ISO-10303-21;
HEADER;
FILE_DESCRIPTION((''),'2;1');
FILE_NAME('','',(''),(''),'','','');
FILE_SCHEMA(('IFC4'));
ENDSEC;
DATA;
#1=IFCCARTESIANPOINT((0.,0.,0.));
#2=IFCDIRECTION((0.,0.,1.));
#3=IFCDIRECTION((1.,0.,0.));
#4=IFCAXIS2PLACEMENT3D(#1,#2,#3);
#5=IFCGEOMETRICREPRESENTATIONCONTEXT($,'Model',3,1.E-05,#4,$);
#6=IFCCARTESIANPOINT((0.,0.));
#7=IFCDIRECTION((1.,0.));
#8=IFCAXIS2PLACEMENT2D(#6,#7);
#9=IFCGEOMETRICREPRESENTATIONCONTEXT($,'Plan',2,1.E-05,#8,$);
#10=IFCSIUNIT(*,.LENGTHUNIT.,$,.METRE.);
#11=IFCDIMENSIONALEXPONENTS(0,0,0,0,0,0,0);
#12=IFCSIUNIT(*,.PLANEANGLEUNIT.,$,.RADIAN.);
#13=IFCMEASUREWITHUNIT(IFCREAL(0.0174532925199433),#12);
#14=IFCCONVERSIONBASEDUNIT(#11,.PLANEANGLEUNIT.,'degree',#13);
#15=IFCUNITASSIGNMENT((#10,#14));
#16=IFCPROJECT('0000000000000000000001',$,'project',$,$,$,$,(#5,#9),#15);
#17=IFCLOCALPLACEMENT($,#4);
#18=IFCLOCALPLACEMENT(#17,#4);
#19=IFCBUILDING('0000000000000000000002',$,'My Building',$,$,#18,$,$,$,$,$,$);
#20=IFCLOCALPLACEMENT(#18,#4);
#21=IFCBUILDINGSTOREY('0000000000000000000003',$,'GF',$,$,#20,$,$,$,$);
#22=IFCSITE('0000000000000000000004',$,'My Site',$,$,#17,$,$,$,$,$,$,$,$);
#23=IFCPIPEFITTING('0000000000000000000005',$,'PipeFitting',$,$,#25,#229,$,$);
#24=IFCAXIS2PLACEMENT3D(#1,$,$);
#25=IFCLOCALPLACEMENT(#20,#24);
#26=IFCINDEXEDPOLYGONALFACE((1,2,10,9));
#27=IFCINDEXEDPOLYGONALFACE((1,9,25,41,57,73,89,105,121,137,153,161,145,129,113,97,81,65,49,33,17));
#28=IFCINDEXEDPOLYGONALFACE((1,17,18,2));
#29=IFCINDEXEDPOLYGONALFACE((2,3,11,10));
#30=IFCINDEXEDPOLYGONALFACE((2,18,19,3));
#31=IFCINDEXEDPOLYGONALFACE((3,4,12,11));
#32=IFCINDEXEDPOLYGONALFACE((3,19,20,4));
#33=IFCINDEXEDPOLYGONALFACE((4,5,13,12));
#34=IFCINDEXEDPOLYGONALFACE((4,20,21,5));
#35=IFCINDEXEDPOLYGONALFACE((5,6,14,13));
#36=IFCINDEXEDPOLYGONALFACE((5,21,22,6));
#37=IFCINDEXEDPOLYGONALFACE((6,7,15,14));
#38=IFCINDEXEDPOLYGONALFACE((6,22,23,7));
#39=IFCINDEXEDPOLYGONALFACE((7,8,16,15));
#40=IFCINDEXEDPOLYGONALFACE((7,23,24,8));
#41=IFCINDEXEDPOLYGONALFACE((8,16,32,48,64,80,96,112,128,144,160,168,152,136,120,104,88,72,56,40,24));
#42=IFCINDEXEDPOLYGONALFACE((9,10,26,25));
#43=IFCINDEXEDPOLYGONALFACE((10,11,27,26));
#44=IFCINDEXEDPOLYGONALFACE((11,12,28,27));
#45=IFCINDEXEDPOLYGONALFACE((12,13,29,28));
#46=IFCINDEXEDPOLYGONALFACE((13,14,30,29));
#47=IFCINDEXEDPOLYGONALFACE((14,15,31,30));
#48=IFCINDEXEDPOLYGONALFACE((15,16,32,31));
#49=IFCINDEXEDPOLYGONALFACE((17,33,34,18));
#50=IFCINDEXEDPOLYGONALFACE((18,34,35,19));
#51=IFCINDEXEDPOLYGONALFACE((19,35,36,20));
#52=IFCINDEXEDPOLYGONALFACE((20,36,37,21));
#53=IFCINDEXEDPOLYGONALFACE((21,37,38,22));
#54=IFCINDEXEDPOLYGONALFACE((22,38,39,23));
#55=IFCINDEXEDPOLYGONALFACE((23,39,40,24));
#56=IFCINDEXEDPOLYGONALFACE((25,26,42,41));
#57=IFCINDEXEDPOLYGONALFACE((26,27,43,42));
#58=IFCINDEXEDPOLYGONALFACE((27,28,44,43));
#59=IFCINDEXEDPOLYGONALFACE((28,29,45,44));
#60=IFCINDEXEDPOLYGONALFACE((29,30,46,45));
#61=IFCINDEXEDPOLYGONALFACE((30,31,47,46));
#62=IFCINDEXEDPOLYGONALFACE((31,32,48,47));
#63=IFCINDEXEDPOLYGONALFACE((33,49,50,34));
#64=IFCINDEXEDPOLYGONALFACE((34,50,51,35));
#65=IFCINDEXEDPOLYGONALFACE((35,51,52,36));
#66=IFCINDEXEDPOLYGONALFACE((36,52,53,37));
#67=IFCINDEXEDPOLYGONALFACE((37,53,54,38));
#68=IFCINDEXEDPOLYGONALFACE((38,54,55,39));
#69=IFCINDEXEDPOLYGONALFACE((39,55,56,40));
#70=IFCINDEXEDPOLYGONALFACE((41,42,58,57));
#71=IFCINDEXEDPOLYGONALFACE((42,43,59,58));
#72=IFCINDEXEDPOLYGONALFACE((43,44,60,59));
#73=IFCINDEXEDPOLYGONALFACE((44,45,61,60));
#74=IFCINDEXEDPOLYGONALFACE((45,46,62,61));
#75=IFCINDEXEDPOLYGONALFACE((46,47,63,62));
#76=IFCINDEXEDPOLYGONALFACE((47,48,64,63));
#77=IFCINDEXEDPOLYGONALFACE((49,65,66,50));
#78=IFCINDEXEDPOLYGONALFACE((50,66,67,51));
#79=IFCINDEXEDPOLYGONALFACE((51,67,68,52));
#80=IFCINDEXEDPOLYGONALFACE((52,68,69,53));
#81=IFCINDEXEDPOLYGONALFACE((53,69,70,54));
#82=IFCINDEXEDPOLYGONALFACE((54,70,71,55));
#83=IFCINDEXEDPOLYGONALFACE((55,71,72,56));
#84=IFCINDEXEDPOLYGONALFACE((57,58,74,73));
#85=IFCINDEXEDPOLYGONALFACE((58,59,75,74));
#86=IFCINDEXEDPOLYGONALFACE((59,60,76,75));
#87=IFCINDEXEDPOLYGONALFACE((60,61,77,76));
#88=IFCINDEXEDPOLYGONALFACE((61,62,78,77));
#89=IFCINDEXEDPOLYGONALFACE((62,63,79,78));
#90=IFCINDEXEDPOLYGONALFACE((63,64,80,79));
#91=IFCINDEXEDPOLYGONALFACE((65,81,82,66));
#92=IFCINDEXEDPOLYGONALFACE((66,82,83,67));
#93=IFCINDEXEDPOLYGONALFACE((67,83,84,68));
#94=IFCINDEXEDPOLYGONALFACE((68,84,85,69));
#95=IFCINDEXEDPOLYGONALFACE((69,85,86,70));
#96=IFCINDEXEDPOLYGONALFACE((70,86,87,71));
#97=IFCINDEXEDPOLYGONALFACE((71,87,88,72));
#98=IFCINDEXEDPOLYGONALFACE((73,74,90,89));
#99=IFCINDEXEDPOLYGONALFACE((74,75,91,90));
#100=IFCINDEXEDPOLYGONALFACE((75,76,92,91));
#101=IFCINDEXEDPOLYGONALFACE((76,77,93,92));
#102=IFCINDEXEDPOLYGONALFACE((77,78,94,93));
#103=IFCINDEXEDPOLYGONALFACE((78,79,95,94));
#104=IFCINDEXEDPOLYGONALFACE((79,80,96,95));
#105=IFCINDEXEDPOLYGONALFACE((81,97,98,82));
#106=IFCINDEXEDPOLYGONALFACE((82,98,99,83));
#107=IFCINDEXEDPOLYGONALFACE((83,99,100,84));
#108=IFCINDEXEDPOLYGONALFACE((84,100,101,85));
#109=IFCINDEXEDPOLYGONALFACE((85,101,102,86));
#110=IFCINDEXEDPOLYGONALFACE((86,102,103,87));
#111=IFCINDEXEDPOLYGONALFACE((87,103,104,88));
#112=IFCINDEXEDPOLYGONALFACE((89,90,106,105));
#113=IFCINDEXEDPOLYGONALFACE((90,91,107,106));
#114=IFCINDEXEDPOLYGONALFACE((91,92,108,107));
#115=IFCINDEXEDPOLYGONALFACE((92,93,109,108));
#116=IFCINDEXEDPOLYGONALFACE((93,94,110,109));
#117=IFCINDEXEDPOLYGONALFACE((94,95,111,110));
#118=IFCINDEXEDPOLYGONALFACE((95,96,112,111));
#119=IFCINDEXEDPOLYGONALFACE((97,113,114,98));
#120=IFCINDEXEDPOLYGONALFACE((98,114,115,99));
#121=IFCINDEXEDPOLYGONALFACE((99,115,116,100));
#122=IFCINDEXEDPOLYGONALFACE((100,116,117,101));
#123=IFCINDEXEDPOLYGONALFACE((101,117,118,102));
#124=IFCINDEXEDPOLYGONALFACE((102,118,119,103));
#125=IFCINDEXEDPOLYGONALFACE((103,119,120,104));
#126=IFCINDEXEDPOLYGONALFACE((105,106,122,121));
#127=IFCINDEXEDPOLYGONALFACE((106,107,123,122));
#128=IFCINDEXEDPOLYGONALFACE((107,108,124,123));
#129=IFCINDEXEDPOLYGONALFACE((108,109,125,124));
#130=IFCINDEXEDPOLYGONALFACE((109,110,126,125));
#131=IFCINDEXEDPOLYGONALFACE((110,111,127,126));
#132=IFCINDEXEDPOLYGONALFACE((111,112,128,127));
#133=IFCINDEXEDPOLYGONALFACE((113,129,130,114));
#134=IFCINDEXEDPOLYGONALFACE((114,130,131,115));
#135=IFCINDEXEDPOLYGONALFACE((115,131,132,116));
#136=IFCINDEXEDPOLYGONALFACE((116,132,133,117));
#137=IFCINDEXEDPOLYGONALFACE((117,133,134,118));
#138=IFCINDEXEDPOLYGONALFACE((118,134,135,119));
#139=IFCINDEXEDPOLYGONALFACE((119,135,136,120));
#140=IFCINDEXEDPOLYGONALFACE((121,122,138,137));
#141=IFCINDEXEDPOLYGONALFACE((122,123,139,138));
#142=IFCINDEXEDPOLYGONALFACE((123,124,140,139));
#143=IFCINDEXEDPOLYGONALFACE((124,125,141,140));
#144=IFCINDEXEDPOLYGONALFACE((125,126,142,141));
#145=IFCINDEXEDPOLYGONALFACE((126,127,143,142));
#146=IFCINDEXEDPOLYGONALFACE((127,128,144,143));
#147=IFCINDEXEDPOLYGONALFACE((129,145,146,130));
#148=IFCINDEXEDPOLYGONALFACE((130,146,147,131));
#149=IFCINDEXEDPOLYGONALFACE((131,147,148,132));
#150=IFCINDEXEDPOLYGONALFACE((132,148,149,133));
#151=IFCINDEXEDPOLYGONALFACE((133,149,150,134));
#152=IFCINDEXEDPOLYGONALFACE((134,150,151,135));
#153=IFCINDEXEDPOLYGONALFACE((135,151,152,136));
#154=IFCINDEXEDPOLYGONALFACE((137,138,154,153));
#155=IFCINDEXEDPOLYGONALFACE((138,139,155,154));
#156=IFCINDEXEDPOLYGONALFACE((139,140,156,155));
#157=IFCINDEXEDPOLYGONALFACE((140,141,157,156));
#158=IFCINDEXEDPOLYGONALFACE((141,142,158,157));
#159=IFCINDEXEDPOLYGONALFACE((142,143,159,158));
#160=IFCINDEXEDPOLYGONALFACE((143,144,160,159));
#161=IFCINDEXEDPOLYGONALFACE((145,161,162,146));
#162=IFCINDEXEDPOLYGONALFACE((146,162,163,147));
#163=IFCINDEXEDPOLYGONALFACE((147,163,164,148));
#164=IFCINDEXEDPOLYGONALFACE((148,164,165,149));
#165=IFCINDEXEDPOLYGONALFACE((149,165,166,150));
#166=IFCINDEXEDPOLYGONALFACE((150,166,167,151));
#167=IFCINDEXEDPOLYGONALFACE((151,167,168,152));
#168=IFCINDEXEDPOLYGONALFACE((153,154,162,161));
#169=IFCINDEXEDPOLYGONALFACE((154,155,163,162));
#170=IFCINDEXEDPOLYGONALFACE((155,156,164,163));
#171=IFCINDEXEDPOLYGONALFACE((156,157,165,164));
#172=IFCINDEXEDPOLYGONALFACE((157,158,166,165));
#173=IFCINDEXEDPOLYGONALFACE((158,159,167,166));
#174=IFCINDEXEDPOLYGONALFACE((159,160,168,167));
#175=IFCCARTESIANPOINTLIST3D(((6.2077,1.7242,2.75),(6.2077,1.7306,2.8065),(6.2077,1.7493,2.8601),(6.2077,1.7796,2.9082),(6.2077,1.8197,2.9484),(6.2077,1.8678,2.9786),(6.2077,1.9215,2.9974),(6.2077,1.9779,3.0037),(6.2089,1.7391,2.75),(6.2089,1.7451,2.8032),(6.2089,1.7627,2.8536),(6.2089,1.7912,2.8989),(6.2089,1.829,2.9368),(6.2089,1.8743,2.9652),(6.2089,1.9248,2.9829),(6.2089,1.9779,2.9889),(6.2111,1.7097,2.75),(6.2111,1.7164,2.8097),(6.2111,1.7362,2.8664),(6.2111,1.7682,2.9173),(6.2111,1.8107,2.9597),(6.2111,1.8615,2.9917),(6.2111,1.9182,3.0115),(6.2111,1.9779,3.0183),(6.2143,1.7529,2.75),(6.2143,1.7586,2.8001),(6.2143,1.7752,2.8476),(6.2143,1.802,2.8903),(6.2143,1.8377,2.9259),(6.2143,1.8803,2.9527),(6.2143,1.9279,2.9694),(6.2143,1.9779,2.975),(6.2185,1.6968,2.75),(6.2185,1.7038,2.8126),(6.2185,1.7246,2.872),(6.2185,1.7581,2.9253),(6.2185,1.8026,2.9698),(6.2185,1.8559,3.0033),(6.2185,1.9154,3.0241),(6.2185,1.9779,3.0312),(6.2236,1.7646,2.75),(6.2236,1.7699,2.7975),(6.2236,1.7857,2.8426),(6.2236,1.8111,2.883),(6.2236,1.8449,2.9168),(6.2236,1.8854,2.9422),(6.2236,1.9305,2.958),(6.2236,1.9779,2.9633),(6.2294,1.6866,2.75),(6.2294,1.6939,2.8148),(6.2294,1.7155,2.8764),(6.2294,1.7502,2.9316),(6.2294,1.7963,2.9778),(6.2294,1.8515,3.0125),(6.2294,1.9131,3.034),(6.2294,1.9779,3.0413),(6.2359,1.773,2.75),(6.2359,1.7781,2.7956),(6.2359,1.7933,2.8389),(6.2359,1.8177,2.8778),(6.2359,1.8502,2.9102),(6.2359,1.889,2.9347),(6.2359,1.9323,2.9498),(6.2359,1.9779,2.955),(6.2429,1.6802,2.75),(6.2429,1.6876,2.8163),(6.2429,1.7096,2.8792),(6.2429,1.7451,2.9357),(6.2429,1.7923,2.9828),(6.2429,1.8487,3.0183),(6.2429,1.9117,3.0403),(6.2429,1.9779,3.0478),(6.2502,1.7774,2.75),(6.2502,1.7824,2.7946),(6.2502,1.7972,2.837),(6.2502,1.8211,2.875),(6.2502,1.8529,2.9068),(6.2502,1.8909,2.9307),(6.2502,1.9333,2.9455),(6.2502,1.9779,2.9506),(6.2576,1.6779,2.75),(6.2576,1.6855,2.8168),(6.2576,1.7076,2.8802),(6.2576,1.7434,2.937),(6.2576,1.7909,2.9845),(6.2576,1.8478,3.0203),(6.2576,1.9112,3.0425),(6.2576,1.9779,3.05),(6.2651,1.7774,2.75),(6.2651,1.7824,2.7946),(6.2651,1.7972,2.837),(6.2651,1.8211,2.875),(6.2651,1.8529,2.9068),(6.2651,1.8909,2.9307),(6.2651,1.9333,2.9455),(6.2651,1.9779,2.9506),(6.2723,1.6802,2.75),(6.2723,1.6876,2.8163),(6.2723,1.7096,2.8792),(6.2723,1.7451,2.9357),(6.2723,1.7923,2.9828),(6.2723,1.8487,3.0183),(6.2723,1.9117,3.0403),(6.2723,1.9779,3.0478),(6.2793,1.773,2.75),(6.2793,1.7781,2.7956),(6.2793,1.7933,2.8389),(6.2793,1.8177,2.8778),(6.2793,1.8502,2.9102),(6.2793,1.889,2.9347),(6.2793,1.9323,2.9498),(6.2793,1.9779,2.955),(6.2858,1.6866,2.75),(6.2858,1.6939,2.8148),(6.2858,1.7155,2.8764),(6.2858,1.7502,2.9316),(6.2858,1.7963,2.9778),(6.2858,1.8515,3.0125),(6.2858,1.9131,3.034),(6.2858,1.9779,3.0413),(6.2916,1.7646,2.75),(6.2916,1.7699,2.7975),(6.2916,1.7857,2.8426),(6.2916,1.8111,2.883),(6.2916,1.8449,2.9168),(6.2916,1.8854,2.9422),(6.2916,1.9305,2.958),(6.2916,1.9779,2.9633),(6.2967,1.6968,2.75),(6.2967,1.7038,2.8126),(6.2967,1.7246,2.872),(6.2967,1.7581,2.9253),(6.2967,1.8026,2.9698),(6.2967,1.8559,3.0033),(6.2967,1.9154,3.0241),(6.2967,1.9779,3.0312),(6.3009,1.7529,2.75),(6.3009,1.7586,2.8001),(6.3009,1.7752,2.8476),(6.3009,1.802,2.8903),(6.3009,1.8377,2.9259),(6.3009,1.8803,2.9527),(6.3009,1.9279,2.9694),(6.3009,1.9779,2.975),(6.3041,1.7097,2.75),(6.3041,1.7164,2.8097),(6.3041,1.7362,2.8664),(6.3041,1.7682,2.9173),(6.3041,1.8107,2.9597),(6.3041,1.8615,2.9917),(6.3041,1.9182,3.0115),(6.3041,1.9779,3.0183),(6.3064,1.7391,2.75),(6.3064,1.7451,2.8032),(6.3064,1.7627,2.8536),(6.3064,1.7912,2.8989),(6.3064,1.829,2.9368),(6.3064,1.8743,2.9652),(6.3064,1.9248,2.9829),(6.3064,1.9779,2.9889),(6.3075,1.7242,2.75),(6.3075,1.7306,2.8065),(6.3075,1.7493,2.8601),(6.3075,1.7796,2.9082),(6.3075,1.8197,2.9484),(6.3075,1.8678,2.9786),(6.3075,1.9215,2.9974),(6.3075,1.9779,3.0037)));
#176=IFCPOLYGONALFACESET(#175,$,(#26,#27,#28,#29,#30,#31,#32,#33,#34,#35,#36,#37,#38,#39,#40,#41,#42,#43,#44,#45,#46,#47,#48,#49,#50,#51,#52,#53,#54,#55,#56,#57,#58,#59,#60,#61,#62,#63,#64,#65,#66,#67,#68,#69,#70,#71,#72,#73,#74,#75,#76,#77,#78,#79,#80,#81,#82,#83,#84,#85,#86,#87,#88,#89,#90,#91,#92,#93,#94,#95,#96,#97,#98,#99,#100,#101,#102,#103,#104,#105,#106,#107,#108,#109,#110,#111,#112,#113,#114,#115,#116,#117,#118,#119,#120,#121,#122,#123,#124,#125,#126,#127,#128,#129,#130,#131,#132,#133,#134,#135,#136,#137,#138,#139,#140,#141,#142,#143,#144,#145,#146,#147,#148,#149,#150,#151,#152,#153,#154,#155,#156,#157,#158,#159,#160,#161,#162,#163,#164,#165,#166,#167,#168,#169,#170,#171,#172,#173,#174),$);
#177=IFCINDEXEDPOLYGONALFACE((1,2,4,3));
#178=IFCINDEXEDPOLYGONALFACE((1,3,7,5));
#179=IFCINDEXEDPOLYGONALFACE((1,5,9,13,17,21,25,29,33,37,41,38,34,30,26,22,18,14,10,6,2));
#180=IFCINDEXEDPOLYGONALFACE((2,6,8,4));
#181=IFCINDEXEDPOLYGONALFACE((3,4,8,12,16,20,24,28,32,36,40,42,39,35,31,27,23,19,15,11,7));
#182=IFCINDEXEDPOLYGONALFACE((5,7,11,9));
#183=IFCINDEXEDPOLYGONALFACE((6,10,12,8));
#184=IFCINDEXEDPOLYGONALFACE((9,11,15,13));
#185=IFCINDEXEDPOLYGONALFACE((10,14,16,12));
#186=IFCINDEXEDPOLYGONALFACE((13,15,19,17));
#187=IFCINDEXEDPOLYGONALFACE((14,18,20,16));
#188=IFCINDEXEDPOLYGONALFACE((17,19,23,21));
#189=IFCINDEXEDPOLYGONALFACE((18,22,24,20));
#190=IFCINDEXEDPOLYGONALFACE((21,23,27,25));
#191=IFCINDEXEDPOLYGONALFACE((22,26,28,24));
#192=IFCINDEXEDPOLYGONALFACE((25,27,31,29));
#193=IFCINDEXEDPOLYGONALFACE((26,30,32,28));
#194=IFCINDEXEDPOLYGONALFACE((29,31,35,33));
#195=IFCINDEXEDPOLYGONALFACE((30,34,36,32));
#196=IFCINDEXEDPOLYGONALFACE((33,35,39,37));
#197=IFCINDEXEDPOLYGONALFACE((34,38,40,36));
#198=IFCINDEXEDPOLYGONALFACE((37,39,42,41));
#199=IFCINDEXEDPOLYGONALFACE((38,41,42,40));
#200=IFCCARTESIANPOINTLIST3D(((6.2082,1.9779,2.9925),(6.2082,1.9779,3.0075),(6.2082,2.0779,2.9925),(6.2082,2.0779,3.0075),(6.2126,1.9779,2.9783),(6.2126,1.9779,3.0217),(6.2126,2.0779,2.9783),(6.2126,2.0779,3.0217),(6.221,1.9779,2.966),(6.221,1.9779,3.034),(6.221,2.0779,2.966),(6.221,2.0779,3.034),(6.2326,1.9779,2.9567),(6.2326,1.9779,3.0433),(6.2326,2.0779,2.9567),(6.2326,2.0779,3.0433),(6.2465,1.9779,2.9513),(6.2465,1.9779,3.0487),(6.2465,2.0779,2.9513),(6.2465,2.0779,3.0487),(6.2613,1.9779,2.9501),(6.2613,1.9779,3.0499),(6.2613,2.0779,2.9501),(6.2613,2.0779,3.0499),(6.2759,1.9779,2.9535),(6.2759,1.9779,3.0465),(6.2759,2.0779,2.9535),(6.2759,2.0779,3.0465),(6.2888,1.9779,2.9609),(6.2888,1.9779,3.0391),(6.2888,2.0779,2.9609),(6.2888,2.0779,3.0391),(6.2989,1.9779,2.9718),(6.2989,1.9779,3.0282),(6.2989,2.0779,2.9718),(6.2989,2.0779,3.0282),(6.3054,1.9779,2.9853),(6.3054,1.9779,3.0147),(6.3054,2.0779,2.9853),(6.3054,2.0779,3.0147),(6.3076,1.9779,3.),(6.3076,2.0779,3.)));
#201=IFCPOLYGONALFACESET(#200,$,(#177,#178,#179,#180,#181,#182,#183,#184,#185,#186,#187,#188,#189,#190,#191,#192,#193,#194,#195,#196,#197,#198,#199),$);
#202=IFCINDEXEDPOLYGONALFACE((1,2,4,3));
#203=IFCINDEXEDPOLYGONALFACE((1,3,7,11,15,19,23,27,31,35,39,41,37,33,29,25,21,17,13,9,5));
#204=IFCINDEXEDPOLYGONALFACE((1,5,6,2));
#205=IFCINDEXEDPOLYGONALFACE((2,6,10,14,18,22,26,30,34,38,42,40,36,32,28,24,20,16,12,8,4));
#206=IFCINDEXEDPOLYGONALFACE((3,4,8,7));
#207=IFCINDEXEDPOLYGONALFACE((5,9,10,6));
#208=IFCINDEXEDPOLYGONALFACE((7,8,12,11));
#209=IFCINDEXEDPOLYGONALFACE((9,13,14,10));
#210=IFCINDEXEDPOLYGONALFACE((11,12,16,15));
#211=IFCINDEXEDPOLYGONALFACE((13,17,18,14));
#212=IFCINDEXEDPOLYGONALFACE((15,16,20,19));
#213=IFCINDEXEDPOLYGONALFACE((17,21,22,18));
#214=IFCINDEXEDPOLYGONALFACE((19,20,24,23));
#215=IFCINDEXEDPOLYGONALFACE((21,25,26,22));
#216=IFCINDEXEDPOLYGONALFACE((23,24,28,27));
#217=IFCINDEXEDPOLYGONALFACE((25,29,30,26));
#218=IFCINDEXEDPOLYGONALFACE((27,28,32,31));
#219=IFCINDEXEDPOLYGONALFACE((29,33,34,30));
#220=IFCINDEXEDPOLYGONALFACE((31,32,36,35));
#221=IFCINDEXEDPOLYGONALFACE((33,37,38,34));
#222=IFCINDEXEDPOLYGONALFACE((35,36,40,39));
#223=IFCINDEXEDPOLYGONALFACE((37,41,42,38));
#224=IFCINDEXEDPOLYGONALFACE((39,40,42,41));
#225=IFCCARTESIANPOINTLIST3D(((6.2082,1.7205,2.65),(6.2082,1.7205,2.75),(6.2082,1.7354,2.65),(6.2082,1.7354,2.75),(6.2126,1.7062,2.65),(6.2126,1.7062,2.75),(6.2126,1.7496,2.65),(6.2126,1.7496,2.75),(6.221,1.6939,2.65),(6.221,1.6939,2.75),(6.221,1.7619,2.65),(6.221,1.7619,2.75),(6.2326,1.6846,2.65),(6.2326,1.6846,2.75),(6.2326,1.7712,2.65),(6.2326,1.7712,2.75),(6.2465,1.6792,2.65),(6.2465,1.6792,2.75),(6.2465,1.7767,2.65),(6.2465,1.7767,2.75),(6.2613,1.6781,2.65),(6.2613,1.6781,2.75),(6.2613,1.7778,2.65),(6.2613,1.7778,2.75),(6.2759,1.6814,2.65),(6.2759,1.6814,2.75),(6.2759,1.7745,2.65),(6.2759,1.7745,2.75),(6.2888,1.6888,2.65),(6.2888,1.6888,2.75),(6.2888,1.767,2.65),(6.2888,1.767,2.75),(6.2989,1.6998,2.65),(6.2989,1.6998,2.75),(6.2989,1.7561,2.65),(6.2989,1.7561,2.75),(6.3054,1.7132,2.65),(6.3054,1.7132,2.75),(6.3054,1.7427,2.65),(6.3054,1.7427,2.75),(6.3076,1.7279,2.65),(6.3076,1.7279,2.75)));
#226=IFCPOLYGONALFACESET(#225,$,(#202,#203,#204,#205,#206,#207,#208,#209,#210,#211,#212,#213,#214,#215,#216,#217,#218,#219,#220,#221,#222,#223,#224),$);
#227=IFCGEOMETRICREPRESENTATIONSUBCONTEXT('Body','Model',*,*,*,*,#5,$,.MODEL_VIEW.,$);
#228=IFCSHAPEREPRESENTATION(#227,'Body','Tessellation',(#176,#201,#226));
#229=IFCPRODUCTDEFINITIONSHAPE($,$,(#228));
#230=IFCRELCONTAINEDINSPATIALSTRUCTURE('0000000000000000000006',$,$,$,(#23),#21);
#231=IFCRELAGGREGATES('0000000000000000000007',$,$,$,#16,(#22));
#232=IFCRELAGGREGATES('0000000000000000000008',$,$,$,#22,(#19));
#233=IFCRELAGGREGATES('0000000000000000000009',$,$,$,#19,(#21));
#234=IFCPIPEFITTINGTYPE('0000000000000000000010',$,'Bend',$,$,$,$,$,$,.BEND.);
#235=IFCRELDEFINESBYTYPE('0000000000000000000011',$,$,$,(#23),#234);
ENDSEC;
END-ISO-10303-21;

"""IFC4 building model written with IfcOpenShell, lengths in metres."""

from ifc_helpers import new_model, entity, si_unit, converted_unit, frame, origin_with_axes, origin_2d_with_axis, place, context, subcontext, project, spatial, circle, extrude, source, transform, mapped, type_object, type_shapes, element, save


model = new_model("IFC4")

# Units and contexts
model_context = context("Model", 3, precision=1e-05, world=origin_with_axes())
plan_context = context("Plan", 2, precision=1e-05, world=origin_2d_with_axis())
body_context_1 = subcontext(model_context, "Body", "Model", "MODEL_VIEW")
ifc_project = project(units=[si_unit("LENGTHUNIT", "METRE"), converted_unit("PLANEANGLEUNIT", "degree", entity("IfcReal", 0.0174532925199433), si_unit("PLANEANGLEUNIT", "RADIAN"), dimensions=[0, 0, 0, 0, 0, 0, 0])], contexts=[model_context, plan_context])

# Site, building, storey
site_placement = place(None, origin_with_axes())
site = spatial("IfcSite", under=ifc_project, at=site_placement, Name="My Site")
building_placement = place(site_placement, origin_with_axes())
building = spatial("IfcBuilding", under=site, at=building_placement, Name="My Building")
storey_placement = place(building_placement, origin_with_axes())
storey = spatial("IfcBuildingStorey", under=building, at=storey_placement, Name="GF")

# Pipe fitting
pipe_fitting_type = type_object("IfcPipeFittingType", Name="Bend", PredefinedType="BEND")
shared_shape_1 = source(origin_with_axes(), body_context_1, "Body", "SolidModel", [
    entity("IfcSweptDiskSolid", entity("IfcIndexedPolyCurve", entity("IfcCartesianPointList3D", [[0.0, 0.0, 0.1], [0.0, -0.0732, 0.2768], [0.0, -0.25, 0.35]]), [entity("IfcArcIndex", [1, 2, 3])]), 0.05),
    extrude(circle(Radius=0.05), origin_with_axes(), (0.0, 0.0, 1.0), 0.1),
    extrude(circle(Radius=0.05), frame((0.0, -0.25, 0.35), z_axis=(0.0, -1.0, 0.0), x_axis=(1.0, 0.0, 0.0)), (0.0, 0.0, 1.0), 0.1),
])
type_shapes(pipe_fitting_type, [shared_shape_1])
for number, where, z_axis, x_axis, name in (
    (1, (6.2576, 2.0779, 3.0), (0.0, -1.0, 0.0), (1.0, 0.0, 0.0), "PipeFitting"),
):
    element("IfcPipeFitting", number, at=place(storey_placement, frame(where, z_axis=z_axis, x_axis=x_axis)), inside=storey, type_object=pipe_fitting_type, Name=name, context=body_context_1, shape_type="MappedRepresentation", body=[
        mapped(shared_shape_1, transform((0.0, 0.0, 0.0), x_axis=(1.0, 0.0, 0.0), y_axis=(0.0, 1.0, 0.0), z_axis=(0.0, 0.0, 1.0), scale=1.0)),
    ])

save(model, "model.ifc")
